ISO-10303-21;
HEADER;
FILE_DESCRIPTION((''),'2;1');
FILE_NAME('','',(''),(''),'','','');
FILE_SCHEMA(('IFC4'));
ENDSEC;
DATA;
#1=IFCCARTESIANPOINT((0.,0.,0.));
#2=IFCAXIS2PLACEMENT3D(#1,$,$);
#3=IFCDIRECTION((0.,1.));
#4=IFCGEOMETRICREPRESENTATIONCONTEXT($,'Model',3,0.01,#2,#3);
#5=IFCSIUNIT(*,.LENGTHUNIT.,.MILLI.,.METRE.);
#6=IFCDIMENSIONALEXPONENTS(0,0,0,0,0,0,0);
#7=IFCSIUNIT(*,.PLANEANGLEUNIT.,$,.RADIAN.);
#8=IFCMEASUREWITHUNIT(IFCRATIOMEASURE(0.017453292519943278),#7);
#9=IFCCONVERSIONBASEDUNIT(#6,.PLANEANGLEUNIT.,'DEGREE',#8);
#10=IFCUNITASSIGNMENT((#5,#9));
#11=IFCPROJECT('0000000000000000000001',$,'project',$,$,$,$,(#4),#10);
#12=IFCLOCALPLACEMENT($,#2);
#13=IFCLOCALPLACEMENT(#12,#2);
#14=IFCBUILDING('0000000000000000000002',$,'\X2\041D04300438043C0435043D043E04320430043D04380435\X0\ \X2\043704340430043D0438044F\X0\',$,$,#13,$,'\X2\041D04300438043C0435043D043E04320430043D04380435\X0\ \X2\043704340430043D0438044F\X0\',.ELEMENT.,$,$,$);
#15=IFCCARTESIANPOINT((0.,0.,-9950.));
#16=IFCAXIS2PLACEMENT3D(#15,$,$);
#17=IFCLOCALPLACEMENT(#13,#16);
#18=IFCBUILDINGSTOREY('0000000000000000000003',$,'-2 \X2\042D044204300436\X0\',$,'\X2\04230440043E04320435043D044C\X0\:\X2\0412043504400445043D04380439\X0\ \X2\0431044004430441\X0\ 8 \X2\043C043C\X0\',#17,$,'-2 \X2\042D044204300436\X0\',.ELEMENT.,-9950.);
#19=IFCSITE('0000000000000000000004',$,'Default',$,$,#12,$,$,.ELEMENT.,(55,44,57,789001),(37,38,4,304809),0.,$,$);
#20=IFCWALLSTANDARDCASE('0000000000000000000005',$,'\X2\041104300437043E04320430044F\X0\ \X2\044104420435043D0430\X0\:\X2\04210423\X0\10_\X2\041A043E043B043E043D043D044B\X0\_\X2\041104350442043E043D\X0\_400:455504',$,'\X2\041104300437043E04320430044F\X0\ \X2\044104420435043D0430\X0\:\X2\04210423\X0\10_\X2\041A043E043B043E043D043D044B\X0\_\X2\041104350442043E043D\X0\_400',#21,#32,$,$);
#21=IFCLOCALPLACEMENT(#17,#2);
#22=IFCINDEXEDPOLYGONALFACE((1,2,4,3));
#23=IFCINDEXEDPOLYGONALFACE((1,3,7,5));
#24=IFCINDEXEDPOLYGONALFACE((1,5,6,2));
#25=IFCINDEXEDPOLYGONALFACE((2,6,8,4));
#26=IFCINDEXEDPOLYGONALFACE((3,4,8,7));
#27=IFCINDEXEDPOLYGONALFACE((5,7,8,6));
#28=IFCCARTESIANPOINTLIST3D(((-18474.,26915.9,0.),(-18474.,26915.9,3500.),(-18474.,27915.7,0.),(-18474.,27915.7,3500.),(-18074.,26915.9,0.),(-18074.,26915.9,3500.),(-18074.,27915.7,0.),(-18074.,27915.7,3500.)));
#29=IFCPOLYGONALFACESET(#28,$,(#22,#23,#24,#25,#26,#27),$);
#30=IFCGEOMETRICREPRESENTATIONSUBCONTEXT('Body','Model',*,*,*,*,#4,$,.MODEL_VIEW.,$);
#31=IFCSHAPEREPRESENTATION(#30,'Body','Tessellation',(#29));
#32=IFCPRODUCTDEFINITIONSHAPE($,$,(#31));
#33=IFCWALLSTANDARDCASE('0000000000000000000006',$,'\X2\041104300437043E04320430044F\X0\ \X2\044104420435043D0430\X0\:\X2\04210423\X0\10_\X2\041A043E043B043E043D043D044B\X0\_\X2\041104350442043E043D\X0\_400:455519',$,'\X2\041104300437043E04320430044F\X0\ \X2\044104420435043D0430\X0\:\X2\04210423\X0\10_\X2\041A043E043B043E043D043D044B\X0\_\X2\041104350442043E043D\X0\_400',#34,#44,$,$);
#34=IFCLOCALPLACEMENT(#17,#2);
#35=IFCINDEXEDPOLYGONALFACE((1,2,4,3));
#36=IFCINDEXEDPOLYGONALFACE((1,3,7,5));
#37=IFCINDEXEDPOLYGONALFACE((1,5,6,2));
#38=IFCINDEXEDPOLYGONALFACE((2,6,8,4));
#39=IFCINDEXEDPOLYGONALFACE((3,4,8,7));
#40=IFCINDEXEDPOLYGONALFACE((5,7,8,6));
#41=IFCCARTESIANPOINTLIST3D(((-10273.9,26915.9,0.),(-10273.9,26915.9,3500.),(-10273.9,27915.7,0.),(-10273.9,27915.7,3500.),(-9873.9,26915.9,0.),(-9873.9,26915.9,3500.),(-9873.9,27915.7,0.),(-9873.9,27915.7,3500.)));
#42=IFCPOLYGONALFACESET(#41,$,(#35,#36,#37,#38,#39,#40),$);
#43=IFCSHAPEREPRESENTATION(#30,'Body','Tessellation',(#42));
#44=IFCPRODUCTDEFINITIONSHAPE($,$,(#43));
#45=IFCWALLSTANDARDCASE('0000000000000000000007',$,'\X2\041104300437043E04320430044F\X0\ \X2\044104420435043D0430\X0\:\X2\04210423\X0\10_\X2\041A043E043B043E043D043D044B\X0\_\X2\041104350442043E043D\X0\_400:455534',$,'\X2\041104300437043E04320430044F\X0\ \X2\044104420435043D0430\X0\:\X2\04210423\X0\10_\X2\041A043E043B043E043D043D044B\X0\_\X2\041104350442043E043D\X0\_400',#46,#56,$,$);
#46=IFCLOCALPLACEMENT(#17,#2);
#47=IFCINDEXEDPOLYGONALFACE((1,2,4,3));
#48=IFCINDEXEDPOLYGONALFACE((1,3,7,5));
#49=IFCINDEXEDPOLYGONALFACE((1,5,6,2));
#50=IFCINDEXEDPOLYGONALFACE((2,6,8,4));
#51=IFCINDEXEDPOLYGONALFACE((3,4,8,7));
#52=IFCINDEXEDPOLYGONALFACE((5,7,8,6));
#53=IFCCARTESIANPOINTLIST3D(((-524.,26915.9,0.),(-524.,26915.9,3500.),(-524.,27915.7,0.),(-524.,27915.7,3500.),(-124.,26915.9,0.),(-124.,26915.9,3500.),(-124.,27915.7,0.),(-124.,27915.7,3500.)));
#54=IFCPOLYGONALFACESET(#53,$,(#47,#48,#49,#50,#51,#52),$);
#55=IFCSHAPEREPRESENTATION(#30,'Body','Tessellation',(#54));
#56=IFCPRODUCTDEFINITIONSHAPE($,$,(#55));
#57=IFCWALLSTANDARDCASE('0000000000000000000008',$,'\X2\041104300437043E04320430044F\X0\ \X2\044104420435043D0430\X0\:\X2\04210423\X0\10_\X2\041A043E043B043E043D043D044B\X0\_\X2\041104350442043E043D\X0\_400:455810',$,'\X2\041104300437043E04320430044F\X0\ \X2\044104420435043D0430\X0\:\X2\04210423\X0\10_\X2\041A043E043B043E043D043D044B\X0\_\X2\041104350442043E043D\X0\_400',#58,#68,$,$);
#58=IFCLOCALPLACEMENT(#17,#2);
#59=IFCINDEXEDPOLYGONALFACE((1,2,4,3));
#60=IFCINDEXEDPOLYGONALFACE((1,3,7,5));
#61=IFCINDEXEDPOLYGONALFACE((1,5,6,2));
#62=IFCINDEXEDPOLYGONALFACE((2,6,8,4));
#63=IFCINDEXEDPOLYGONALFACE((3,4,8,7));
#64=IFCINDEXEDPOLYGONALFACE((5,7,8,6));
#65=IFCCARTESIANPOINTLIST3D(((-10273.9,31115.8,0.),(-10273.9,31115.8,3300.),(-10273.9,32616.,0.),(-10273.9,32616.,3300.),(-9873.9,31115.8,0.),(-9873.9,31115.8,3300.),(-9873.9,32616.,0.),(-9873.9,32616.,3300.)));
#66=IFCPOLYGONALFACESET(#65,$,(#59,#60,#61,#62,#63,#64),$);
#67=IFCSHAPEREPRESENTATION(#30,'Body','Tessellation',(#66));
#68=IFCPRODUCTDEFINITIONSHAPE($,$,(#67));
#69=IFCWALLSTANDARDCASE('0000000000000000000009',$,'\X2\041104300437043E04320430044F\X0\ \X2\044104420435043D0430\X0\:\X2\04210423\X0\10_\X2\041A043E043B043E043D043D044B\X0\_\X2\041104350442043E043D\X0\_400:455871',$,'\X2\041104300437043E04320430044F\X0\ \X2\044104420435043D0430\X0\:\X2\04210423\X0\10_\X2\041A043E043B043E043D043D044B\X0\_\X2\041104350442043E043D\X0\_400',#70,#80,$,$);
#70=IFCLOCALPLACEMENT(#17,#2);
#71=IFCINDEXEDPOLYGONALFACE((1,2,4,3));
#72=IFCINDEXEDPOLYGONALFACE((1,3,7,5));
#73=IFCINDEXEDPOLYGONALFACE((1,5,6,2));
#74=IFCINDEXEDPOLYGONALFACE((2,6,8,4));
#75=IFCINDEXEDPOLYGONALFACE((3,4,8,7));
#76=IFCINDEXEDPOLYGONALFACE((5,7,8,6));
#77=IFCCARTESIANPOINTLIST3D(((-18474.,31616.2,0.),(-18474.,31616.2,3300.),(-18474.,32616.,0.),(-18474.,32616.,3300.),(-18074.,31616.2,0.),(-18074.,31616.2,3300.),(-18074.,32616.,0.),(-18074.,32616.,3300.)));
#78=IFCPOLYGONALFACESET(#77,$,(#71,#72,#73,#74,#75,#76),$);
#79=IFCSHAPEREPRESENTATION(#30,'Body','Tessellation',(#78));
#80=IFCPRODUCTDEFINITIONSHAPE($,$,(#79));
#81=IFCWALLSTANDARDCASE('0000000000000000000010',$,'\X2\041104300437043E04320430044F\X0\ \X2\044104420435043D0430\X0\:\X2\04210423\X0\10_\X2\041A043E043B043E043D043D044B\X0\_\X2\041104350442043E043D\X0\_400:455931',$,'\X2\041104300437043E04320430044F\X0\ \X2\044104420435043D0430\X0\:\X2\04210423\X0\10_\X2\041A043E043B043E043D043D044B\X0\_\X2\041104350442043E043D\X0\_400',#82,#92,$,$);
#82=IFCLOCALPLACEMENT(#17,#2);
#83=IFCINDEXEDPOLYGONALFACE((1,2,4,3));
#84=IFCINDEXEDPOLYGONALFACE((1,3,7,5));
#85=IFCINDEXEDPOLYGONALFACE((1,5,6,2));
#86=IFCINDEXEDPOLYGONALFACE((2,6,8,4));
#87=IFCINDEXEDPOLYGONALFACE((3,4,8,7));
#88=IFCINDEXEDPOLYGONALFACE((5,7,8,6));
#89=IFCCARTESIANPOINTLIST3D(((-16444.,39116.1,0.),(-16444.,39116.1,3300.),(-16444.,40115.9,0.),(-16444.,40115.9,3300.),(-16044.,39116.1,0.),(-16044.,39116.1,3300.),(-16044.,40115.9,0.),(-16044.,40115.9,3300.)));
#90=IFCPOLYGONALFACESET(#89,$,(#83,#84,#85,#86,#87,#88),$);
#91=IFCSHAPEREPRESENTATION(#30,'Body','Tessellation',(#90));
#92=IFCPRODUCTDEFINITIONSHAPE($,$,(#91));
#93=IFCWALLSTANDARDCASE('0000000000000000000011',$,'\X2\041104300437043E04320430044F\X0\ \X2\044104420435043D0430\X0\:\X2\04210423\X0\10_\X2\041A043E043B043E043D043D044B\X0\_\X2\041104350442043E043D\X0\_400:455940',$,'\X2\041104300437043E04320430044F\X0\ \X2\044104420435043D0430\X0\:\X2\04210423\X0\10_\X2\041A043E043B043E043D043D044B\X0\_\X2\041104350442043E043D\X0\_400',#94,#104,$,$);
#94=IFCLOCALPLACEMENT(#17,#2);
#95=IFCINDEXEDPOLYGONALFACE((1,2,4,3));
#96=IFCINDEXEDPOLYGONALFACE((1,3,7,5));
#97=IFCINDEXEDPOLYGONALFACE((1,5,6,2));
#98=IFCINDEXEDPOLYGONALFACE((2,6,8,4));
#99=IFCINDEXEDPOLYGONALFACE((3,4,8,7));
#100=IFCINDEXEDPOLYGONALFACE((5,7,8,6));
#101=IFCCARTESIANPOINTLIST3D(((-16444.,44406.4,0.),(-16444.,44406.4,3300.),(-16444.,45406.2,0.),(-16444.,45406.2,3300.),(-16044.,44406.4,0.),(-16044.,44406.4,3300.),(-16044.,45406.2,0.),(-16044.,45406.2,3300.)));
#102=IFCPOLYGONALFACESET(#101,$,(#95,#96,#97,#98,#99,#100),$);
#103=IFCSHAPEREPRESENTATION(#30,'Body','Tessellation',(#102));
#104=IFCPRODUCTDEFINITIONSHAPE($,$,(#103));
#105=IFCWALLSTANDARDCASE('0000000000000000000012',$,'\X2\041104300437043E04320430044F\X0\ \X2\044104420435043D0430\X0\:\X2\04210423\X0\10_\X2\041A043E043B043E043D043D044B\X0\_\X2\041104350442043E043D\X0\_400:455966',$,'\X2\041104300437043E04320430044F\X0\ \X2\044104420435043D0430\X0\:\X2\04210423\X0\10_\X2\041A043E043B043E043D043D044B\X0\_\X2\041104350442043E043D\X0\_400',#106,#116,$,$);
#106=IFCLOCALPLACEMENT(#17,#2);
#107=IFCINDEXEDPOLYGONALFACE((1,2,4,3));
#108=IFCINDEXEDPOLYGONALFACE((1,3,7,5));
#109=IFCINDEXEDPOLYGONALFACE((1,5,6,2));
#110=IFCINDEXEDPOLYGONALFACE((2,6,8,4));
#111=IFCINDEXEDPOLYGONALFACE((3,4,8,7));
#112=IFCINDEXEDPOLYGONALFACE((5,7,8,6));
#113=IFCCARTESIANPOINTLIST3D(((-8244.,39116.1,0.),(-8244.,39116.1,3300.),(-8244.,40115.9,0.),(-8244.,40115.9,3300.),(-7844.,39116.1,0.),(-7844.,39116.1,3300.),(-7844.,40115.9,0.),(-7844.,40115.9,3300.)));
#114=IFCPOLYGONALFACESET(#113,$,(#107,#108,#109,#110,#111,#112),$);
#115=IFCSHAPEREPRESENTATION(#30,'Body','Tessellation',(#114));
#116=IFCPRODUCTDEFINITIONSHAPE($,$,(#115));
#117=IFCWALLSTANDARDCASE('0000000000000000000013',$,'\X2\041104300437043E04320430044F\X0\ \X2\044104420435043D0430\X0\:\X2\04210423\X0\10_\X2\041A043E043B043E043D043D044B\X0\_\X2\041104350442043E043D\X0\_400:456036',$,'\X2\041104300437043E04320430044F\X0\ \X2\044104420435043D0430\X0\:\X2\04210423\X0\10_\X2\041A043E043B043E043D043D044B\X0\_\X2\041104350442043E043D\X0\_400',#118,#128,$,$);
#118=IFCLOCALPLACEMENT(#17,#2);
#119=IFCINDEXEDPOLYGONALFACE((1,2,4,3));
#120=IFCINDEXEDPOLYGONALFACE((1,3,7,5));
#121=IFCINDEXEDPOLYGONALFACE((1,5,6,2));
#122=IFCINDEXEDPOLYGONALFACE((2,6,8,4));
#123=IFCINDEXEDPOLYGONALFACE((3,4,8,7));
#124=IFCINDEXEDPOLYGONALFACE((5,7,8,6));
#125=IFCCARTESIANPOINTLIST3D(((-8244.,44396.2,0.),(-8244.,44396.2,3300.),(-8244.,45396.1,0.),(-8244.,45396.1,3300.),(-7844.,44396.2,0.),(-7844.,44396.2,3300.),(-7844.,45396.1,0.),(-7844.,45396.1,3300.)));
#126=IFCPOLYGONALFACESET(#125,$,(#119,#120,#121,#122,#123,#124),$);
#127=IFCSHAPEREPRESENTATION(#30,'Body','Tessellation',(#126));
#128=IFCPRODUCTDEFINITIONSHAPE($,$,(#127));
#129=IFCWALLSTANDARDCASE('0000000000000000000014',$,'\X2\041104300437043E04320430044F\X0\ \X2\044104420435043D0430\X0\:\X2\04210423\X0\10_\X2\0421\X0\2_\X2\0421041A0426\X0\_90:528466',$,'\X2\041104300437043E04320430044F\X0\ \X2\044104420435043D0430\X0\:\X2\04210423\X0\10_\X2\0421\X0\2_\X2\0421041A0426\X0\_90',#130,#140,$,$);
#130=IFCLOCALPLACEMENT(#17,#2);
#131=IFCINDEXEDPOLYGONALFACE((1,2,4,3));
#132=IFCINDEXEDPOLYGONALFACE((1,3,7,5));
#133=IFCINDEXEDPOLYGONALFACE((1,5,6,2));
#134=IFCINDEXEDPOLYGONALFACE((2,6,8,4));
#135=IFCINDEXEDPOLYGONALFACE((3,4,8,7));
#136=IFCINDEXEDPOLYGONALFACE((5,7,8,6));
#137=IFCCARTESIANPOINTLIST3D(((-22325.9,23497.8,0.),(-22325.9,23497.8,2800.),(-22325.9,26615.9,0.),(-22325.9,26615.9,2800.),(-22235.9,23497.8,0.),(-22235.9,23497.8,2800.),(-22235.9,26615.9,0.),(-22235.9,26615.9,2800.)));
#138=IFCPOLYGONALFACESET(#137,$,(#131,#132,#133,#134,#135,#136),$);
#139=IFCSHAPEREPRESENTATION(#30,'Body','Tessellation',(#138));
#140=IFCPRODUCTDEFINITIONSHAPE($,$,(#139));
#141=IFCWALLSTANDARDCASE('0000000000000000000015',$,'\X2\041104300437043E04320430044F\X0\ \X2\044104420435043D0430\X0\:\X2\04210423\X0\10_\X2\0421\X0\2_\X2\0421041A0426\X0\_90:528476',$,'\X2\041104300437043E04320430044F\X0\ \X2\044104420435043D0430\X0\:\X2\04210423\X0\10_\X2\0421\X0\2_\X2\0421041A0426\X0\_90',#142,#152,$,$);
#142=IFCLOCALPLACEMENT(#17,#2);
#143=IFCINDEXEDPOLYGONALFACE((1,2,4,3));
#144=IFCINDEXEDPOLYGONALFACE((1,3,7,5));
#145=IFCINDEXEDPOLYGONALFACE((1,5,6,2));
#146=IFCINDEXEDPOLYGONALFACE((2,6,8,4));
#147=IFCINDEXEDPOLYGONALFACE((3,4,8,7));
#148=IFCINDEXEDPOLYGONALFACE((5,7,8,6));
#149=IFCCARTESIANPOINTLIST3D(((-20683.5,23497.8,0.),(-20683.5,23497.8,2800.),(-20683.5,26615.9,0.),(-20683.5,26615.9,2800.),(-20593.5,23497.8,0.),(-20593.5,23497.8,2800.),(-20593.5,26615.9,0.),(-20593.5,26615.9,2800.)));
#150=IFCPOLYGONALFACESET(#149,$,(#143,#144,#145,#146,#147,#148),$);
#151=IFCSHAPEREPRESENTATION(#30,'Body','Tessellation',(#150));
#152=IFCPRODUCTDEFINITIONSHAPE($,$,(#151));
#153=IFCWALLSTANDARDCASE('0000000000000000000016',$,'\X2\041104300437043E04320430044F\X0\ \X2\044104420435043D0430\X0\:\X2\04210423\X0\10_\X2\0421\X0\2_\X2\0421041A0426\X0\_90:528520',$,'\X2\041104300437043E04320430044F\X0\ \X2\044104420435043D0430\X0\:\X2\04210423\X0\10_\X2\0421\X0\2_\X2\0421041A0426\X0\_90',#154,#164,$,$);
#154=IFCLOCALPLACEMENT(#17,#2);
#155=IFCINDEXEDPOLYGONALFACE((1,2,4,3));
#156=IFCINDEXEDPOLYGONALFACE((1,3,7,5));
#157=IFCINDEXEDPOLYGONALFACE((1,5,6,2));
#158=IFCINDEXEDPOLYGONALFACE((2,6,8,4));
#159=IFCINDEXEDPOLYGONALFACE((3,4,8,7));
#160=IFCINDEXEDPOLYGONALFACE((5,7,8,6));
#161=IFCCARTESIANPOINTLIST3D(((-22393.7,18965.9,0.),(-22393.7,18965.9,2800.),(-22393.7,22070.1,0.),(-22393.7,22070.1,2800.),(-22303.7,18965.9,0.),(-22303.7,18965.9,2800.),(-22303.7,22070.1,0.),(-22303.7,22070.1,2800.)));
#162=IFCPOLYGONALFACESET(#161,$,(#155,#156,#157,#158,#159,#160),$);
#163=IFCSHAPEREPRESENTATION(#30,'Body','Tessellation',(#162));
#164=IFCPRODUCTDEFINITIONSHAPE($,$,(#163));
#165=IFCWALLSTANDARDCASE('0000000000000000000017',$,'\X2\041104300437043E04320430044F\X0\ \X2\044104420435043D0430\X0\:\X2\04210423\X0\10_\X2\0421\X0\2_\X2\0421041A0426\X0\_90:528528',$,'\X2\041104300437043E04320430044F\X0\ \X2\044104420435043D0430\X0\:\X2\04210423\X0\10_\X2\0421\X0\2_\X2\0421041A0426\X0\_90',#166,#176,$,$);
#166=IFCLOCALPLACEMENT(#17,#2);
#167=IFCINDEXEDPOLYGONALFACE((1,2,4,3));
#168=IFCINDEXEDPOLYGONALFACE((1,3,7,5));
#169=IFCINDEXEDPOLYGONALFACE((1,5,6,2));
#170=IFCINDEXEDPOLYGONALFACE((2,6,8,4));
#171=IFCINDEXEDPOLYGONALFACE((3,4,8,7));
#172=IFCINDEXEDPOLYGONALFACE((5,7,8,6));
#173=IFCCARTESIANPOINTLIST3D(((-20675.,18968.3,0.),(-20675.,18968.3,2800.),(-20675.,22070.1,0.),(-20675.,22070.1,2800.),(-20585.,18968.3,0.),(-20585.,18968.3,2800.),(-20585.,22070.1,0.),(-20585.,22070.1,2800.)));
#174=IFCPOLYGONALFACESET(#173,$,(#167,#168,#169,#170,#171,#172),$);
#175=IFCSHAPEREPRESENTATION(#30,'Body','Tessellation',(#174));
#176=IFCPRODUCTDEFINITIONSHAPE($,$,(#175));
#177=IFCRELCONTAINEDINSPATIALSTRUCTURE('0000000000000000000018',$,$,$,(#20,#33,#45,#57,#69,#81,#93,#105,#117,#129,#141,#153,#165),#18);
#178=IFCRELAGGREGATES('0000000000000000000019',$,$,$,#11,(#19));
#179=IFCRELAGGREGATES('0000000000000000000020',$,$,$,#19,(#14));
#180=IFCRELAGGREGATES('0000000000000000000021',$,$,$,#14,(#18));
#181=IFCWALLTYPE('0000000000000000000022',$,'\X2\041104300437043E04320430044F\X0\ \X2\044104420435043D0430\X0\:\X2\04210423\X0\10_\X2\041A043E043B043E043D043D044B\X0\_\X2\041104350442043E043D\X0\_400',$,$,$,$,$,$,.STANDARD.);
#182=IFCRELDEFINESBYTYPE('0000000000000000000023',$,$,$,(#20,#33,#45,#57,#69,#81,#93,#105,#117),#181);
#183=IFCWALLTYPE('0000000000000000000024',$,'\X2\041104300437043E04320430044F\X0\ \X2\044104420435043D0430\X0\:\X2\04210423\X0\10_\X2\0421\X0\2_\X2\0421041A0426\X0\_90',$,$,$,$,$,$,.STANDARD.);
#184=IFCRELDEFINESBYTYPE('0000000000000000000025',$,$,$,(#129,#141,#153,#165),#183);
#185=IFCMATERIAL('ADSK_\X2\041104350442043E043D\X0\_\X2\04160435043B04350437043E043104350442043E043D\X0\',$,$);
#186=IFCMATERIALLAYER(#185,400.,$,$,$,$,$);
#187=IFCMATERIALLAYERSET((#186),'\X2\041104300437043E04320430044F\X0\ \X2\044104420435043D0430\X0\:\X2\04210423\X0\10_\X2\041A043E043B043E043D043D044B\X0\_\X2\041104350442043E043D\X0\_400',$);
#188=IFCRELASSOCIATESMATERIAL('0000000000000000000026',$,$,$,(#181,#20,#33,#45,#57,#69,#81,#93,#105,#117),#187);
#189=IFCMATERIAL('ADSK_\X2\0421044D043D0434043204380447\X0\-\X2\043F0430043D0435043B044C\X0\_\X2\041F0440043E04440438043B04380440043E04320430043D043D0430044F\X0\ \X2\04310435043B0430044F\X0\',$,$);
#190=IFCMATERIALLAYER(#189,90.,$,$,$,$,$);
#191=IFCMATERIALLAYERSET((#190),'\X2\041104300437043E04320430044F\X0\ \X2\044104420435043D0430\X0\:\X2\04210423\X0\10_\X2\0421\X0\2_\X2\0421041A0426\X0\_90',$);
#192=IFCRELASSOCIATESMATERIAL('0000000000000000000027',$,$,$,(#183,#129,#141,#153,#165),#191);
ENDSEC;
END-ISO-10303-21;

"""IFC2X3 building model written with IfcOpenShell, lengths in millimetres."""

from ifc_helpers import new_model, entity, si_unit, converted_unit, direction, frame, frame_2d, origin, place, context, subcontext, project, spatial, rectangle, extrude, material, layer, layer_set, layer_usage, type_object, element, save


model = new_model("IFC2X3")

# Units and contexts
model_context = context("Model", 3, precision=0.01, world=origin(), true_north=direction((0.0, 1.0)))
body_context = subcontext(model_context, "Body", "Model", "MODEL_VIEW")
ifc_project = project(units=[si_unit("LENGTHUNIT", "METRE", prefix="MILLI"), converted_unit("PLANEANGLEUNIT", "DEGREE", entity("IfcRatioMeasure", 0.017453292519943278), si_unit("PLANEANGLEUNIT", "RADIAN"), dimensions=[0, 0, 0, 0, 0, 0, 0])], contexts=[model_context])

# Site, building, storey
site_placement = place(None, origin())
site = spatial("IfcSite", under=ifc_project, at=site_placement, Name="Default", CompositionType="ELEMENT", RefLatitude=(55, 44, 57, 789001), RefLongitude=(37, 38, 4, 304809), RefElevation=0.0)
building_placement = place(site_placement, origin())
building = spatial("IfcBuilding", under=site, at=building_placement, Name="Наименование здания", LongName="Наименование здания", CompositionType="ELEMENT")
storey_placement = place(building_placement, frame((0.0, 0.0, -9950.0)))
storey = spatial("IfcBuildingStorey", under=building, at=storey_placement, Name="-2 Этаж", ObjectType="Уровень:Верхний брус 8 мм", LongName="-2 Этаж", CompositionType="ELEMENT", Elevation=-9950.0)

# Walls
ifc_material_1 = material(Name="ADSK_Бетон_Железобетон")
ifc_layer_1 = layer(ifc_material_1, 400.0)
ifc_layer_set_1 = layer_set([ifc_layer_1], Name="Базовая стена:СУ10_Колонны_Бетон_400")
ifc_layer_usage_1 = layer_usage(ifc_layer_set_1, "AXIS2", "NEGATIVE", 200.0)
wall_type_1 = type_object("IfcWallType", Name="Базовая стена:СУ10_Колонны_Бетон_400", PredefinedType="STANDARD", material=ifc_layer_set_1)
for number, where, z_axis, x_axis, name in (
    (1, (-18274.0, 26915.9, 0.0), (0.0, 0.0, 1.0), (0.0, 1.0, 0.0), "Базовая стена:СУ10_Колонны_Бетон_400:455504"),
    (2, (-10073.9, 26915.9, 0.0), (0.0, 0.0, 1.0), (0.0, 1.0, 0.0), "Базовая стена:СУ10_Колонны_Бетон_400:455519"),
    (3, (-324.0, 26915.9, 0.0), (0.0, 0.0, 1.0), (0.0, 1.0, 0.0), "Базовая стена:СУ10_Колонны_Бетон_400:455534"),
):
    element("IfcWallStandardCase", number, at=place(storey_placement, frame(where, z_axis=z_axis, x_axis=x_axis)), inside=storey, type_object=wall_type_1, material=ifc_layer_usage_1, Name=name, ObjectType="Базовая стена:СУ10_Колонны_Бетон_400", context=body_context, shape_type="SweptSolid", body=[
        extrude(rectangle(XDim=999.8, YDim=400.0, at=frame_2d((499.9, 0.0), x_axis=(-1.0, 0.0))), origin(), (0.0, 0.0, 1.0), 3500.0),
    ])
wall_1_placement = place(storey_placement, frame((-10073.9, 31115.8, 0.0), z_axis=(0.0, 0.0, 1.0), x_axis=(0.0, 1.0, 0.0)))
element("IfcWallStandardCase", 4, at=wall_1_placement, inside=storey, type_object=wall_type_1, material=ifc_layer_usage_1, Name="Базовая стена:СУ10_Колонны_Бетон_400:455810", ObjectType="Базовая стена:СУ10_Колонны_Бетон_400", context=body_context, shape_type="SweptSolid", body=[
    extrude(rectangle(XDim=1500.2, YDim=400.0, at=frame_2d((750.1, 0.0), x_axis=(-1.0, 0.0))), origin(), (0.0, 0.0, 1.0), 3300.0),
])
for number, where, z_axis, x_axis, name in (
    (5, (-18274.0, 31616.2, 0.0), (0.0, 0.0, 1.0), (0.0, 1.0, 0.0), "Базовая стена:СУ10_Колонны_Бетон_400:455871"),
    (6, (-16244.0, 39116.1, 0.0), (0.0, 0.0, 1.0), (0.0, 1.0, 0.0), "Базовая стена:СУ10_Колонны_Бетон_400:455931"),
    (7, (-16244.0, 44406.4, 0.0), (0.0, 0.0, 1.0), (0.0, 1.0, 0.0), "Базовая стена:СУ10_Колонны_Бетон_400:455940"),
    (8, (-8044.0, 39116.1, 0.0), (0.0, 0.0, 1.0), (0.0, 1.0, 0.0), "Базовая стена:СУ10_Колонны_Бетон_400:455966"),
    (9, (-8044.0, 44396.2, 0.0), (0.0, 0.0, 1.0), (0.0, 1.0, 0.0), "Базовая стена:СУ10_Колонны_Бетон_400:456036"),
):
    element("IfcWallStandardCase", number, at=place(storey_placement, frame(where, z_axis=z_axis, x_axis=x_axis)), inside=storey, type_object=wall_type_1, material=ifc_layer_usage_1, Name=name, ObjectType="Базовая стена:СУ10_Колонны_Бетон_400", context=body_context, shape_type="SweptSolid", body=[
        extrude(rectangle(XDim=999.8, YDim=400.0, at=frame_2d((499.9, 0.0), x_axis=(-1.0, 0.0))), origin(), (0.0, 0.0, 1.0), 3300.0),
    ])
ifc_material_2 = material(Name="ADSK_Сэндвич-панель_Профилированная белая")
ifc_layer_2 = layer(ifc_material_2, 90.0)
ifc_layer_set_2 = layer_set([ifc_layer_2], Name="Базовая стена:СУ10_С2_СКЦ_90")
ifc_layer_usage_2 = layer_usage(ifc_layer_set_2, "AXIS2", "NEGATIVE", 45.0)
wall_type_2 = type_object("IfcWallType", Name="Базовая стена:СУ10_С2_СКЦ_90", PredefinedType="STANDARD", material=ifc_layer_set_2)
wall_2_placement = place(storey_placement, frame((-22280.9, 26615.9, 0.0), z_axis=(0.0, 0.0, 1.0), x_axis=(0.0, -1.0, 0.0)))
element("IfcWallStandardCase", 10, at=wall_2_placement, inside=storey, type_object=wall_type_2, material=ifc_layer_usage_2, Name="Базовая стена:СУ10_С2_СКЦ_90:528466", ObjectType="Базовая стена:СУ10_С2_СКЦ_90", context=body_context, shape_type="SweptSolid", body=[
    extrude(rectangle(XDim=3118.1, YDim=90.0, at=frame_2d((1559.1, 0.0), x_axis=(-1.0, 0.0))), origin(), (0.0, 0.0, 1.0), 2800.0),
])
wall_3_placement = place(storey_placement, frame((-20638.5, 26615.9, 0.0), z_axis=(0.0, 0.0, 1.0), x_axis=(0.0, -1.0, 0.0)))
element("IfcWallStandardCase", 11, at=wall_3_placement, inside=storey, type_object=wall_type_2, material=ifc_layer_usage_2, Name="Базовая стена:СУ10_С2_СКЦ_90:528476", ObjectType="Базовая стена:СУ10_С2_СКЦ_90", context=body_context, shape_type="SweptSolid", body=[
    extrude(rectangle(XDim=3118.1, YDim=90.0, at=frame_2d((1559.1, 0.0), x_axis=(-1.0, 0.0))), origin(), (0.0, 0.0, 1.0), 2800.0),
])
wall_4_placement = place(storey_placement, frame((-22348.7, 22070.1, 0.0), z_axis=(0.0, 0.0, 1.0), x_axis=(0.0, -1.0, 0.0)))
element("IfcWallStandardCase", 12, at=wall_4_placement, inside=storey, type_object=wall_type_2, material=ifc_layer_usage_2, Name="Базовая стена:СУ10_С2_СКЦ_90:528520", ObjectType="Базовая стена:СУ10_С2_СКЦ_90", context=body_context, shape_type="SweptSolid", body=[
    extrude(rectangle(XDim=3104.2, YDim=90.0, at=frame_2d((1552.1, 0.0), x_axis=(-1.0, 0.0))), origin(), (0.0, 0.0, 1.0), 2800.0),
])
wall_5_placement = place(storey_placement, frame((-20630.0, 22070.1, 0.0), z_axis=(0.0, 0.0, 1.0), x_axis=(0.0, -1.0, 0.0)))
element("IfcWallStandardCase", 13, at=wall_5_placement, inside=storey, type_object=wall_type_2, material=ifc_layer_usage_2, Name="Базовая стена:СУ10_С2_СКЦ_90:528528", ObjectType="Базовая стена:СУ10_С2_СКЦ_90", context=body_context, shape_type="SweptSolid", body=[
    extrude(rectangle(XDim=3101.8, YDim=90.0, at=frame_2d((1550.9, 0.0), x_axis=(-1.0, 0.0))), origin(), (0.0, 0.0, 1.0), 2800.0),
])

save(model, "model.ifc")
